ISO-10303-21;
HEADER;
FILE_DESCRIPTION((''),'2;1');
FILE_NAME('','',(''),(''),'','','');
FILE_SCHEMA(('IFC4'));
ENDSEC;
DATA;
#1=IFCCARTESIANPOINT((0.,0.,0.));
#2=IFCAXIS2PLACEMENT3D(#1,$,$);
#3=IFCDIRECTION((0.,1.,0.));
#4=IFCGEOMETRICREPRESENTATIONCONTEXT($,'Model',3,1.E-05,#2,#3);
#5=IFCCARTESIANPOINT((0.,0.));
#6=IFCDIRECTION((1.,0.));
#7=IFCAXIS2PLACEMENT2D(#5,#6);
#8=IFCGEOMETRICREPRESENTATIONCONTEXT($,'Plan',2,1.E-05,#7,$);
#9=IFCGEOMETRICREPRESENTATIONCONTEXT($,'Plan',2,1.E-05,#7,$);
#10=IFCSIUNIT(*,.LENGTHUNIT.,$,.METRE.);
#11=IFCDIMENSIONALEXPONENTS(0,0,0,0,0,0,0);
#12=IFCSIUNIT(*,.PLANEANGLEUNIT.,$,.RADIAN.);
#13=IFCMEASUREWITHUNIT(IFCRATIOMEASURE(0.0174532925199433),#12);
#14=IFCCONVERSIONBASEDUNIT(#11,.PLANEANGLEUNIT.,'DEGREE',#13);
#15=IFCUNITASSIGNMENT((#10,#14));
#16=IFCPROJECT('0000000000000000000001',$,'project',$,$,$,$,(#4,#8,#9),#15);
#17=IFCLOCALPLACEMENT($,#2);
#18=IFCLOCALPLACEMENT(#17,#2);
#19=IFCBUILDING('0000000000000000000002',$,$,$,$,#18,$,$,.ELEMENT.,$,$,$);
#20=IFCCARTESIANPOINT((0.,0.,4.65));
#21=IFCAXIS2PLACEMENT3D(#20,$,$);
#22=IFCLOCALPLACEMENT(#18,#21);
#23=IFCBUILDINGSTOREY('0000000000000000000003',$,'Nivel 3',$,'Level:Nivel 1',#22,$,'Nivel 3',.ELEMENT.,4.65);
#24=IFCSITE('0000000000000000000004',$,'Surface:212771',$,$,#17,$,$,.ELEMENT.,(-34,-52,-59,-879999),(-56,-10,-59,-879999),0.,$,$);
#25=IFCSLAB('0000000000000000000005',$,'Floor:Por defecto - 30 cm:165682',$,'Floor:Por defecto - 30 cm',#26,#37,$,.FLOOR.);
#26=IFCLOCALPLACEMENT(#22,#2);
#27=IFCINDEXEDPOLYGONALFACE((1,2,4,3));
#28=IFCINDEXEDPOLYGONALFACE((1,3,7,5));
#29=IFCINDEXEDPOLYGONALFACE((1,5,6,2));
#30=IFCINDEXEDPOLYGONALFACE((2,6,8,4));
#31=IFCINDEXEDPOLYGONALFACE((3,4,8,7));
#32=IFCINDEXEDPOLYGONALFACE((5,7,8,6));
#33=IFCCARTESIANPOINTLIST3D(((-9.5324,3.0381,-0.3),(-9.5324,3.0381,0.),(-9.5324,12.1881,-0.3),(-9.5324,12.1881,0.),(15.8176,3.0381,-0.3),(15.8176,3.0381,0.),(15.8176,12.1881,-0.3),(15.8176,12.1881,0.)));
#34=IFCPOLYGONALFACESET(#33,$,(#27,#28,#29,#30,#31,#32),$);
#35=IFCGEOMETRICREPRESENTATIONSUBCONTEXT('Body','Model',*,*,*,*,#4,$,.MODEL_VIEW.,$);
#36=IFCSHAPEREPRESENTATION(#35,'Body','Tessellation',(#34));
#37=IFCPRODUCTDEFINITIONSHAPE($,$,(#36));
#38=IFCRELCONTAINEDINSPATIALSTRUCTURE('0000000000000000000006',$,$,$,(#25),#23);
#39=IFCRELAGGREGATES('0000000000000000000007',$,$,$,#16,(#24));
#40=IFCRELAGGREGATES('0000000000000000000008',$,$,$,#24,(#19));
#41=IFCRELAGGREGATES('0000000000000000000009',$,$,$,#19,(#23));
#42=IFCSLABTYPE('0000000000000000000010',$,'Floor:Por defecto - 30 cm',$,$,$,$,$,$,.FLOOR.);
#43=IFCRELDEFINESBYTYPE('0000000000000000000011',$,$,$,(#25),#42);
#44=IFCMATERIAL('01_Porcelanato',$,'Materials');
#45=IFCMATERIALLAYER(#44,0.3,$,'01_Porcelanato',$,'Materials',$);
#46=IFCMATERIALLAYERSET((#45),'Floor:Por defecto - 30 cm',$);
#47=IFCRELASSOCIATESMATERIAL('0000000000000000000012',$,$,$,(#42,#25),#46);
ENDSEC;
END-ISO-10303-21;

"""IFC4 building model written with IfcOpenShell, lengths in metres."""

from ifc_helpers import new_model, entity, si_unit, converted_unit, direction, frame, origin, origin_2d_with_axis, place, context, subcontext, project, spatial, indexed_curve, outline, extrude, material, layer, layer_set, type_object, element, save


model = new_model("IFC4")

# Units and contexts
model_context = context("Model", 3, precision=1e-05, world=origin(), true_north=direction((0.0, 1.0, 0.0)))
plan_context_1 = context("Plan", 2, precision=1e-05, world=origin_2d_with_axis())
plan_context_2 = context("Plan", 2, precision=1e-05, world=origin_2d_with_axis())
body_context = subcontext(model_context, "Body", "Model", "MODEL_VIEW")
ifc_project = project(units=[si_unit("LENGTHUNIT", "METRE"), converted_unit("PLANEANGLEUNIT", "DEGREE", entity("IfcRatioMeasure", 0.0174532925199433), si_unit("PLANEANGLEUNIT", "RADIAN"), dimensions=[0, 0, 0, 0, 0, 0, 0])], contexts=[model_context, plan_context_1, plan_context_2])

# Site, building, storey
site_placement = place(None, origin())
site = spatial("IfcSite", under=ifc_project, at=site_placement, Name="Surface:212771", CompositionType="ELEMENT", RefLatitude=(-34, -52, -59, -879999), RefLongitude=(-56, -10, -59, -879999), RefElevation=0.0)
building_placement = place(site_placement, origin())
building = spatial("IfcBuilding", under=site, at=building_placement, CompositionType="ELEMENT")
storey_placement = place(building_placement, frame((0.0, 0.0, 4.65)))
storey = spatial("IfcBuildingStorey", under=building, at=storey_placement, Name="Nivel 3", ObjectType="Level:Nivel 1", LongName="Nivel 3", CompositionType="ELEMENT", Elevation=4.65)

# Slab
ifc_material = material(Name="01_Porcelanato", Category="Materials")
ifc_layer = layer(ifc_material, 0.3, Name="01_Porcelanato", Category="Materials")
ifc_layer_set = layer_set([ifc_layer], Name="Floor:Por defecto - 30 cm")
slab_type = type_object("IfcSlabType", Name="Floor:Por defecto - 30 cm", PredefinedType="FLOOR", material=ifc_layer_set)
slab_placement = place(storey_placement, origin())
element("IfcSlab", 1, at=slab_placement, inside=storey, type_object=slab_type, material=ifc_layer_set, Name="Floor:Por defecto - 30 cm:165682", ObjectType="Floor:Por defecto - 30 cm", PredefinedType="FLOOR", context=body_context, shape_type="SweptSolid", body=[
    extrude(outline(indexed_curve([(-4.575, -12.675), (4.575, -12.675), (4.575, 12.675), (-4.575, 12.675), (-4.575, -12.675)], self_intersect=False)), frame((3.1426, 7.6131, 0.0), z_axis=(0.0, 0.0, -1.0), x_axis=(0.0, 1.0, 0.0)), (0.0, 0.0, 1.0), 0.3),
])

save(model, "model.ifc")
